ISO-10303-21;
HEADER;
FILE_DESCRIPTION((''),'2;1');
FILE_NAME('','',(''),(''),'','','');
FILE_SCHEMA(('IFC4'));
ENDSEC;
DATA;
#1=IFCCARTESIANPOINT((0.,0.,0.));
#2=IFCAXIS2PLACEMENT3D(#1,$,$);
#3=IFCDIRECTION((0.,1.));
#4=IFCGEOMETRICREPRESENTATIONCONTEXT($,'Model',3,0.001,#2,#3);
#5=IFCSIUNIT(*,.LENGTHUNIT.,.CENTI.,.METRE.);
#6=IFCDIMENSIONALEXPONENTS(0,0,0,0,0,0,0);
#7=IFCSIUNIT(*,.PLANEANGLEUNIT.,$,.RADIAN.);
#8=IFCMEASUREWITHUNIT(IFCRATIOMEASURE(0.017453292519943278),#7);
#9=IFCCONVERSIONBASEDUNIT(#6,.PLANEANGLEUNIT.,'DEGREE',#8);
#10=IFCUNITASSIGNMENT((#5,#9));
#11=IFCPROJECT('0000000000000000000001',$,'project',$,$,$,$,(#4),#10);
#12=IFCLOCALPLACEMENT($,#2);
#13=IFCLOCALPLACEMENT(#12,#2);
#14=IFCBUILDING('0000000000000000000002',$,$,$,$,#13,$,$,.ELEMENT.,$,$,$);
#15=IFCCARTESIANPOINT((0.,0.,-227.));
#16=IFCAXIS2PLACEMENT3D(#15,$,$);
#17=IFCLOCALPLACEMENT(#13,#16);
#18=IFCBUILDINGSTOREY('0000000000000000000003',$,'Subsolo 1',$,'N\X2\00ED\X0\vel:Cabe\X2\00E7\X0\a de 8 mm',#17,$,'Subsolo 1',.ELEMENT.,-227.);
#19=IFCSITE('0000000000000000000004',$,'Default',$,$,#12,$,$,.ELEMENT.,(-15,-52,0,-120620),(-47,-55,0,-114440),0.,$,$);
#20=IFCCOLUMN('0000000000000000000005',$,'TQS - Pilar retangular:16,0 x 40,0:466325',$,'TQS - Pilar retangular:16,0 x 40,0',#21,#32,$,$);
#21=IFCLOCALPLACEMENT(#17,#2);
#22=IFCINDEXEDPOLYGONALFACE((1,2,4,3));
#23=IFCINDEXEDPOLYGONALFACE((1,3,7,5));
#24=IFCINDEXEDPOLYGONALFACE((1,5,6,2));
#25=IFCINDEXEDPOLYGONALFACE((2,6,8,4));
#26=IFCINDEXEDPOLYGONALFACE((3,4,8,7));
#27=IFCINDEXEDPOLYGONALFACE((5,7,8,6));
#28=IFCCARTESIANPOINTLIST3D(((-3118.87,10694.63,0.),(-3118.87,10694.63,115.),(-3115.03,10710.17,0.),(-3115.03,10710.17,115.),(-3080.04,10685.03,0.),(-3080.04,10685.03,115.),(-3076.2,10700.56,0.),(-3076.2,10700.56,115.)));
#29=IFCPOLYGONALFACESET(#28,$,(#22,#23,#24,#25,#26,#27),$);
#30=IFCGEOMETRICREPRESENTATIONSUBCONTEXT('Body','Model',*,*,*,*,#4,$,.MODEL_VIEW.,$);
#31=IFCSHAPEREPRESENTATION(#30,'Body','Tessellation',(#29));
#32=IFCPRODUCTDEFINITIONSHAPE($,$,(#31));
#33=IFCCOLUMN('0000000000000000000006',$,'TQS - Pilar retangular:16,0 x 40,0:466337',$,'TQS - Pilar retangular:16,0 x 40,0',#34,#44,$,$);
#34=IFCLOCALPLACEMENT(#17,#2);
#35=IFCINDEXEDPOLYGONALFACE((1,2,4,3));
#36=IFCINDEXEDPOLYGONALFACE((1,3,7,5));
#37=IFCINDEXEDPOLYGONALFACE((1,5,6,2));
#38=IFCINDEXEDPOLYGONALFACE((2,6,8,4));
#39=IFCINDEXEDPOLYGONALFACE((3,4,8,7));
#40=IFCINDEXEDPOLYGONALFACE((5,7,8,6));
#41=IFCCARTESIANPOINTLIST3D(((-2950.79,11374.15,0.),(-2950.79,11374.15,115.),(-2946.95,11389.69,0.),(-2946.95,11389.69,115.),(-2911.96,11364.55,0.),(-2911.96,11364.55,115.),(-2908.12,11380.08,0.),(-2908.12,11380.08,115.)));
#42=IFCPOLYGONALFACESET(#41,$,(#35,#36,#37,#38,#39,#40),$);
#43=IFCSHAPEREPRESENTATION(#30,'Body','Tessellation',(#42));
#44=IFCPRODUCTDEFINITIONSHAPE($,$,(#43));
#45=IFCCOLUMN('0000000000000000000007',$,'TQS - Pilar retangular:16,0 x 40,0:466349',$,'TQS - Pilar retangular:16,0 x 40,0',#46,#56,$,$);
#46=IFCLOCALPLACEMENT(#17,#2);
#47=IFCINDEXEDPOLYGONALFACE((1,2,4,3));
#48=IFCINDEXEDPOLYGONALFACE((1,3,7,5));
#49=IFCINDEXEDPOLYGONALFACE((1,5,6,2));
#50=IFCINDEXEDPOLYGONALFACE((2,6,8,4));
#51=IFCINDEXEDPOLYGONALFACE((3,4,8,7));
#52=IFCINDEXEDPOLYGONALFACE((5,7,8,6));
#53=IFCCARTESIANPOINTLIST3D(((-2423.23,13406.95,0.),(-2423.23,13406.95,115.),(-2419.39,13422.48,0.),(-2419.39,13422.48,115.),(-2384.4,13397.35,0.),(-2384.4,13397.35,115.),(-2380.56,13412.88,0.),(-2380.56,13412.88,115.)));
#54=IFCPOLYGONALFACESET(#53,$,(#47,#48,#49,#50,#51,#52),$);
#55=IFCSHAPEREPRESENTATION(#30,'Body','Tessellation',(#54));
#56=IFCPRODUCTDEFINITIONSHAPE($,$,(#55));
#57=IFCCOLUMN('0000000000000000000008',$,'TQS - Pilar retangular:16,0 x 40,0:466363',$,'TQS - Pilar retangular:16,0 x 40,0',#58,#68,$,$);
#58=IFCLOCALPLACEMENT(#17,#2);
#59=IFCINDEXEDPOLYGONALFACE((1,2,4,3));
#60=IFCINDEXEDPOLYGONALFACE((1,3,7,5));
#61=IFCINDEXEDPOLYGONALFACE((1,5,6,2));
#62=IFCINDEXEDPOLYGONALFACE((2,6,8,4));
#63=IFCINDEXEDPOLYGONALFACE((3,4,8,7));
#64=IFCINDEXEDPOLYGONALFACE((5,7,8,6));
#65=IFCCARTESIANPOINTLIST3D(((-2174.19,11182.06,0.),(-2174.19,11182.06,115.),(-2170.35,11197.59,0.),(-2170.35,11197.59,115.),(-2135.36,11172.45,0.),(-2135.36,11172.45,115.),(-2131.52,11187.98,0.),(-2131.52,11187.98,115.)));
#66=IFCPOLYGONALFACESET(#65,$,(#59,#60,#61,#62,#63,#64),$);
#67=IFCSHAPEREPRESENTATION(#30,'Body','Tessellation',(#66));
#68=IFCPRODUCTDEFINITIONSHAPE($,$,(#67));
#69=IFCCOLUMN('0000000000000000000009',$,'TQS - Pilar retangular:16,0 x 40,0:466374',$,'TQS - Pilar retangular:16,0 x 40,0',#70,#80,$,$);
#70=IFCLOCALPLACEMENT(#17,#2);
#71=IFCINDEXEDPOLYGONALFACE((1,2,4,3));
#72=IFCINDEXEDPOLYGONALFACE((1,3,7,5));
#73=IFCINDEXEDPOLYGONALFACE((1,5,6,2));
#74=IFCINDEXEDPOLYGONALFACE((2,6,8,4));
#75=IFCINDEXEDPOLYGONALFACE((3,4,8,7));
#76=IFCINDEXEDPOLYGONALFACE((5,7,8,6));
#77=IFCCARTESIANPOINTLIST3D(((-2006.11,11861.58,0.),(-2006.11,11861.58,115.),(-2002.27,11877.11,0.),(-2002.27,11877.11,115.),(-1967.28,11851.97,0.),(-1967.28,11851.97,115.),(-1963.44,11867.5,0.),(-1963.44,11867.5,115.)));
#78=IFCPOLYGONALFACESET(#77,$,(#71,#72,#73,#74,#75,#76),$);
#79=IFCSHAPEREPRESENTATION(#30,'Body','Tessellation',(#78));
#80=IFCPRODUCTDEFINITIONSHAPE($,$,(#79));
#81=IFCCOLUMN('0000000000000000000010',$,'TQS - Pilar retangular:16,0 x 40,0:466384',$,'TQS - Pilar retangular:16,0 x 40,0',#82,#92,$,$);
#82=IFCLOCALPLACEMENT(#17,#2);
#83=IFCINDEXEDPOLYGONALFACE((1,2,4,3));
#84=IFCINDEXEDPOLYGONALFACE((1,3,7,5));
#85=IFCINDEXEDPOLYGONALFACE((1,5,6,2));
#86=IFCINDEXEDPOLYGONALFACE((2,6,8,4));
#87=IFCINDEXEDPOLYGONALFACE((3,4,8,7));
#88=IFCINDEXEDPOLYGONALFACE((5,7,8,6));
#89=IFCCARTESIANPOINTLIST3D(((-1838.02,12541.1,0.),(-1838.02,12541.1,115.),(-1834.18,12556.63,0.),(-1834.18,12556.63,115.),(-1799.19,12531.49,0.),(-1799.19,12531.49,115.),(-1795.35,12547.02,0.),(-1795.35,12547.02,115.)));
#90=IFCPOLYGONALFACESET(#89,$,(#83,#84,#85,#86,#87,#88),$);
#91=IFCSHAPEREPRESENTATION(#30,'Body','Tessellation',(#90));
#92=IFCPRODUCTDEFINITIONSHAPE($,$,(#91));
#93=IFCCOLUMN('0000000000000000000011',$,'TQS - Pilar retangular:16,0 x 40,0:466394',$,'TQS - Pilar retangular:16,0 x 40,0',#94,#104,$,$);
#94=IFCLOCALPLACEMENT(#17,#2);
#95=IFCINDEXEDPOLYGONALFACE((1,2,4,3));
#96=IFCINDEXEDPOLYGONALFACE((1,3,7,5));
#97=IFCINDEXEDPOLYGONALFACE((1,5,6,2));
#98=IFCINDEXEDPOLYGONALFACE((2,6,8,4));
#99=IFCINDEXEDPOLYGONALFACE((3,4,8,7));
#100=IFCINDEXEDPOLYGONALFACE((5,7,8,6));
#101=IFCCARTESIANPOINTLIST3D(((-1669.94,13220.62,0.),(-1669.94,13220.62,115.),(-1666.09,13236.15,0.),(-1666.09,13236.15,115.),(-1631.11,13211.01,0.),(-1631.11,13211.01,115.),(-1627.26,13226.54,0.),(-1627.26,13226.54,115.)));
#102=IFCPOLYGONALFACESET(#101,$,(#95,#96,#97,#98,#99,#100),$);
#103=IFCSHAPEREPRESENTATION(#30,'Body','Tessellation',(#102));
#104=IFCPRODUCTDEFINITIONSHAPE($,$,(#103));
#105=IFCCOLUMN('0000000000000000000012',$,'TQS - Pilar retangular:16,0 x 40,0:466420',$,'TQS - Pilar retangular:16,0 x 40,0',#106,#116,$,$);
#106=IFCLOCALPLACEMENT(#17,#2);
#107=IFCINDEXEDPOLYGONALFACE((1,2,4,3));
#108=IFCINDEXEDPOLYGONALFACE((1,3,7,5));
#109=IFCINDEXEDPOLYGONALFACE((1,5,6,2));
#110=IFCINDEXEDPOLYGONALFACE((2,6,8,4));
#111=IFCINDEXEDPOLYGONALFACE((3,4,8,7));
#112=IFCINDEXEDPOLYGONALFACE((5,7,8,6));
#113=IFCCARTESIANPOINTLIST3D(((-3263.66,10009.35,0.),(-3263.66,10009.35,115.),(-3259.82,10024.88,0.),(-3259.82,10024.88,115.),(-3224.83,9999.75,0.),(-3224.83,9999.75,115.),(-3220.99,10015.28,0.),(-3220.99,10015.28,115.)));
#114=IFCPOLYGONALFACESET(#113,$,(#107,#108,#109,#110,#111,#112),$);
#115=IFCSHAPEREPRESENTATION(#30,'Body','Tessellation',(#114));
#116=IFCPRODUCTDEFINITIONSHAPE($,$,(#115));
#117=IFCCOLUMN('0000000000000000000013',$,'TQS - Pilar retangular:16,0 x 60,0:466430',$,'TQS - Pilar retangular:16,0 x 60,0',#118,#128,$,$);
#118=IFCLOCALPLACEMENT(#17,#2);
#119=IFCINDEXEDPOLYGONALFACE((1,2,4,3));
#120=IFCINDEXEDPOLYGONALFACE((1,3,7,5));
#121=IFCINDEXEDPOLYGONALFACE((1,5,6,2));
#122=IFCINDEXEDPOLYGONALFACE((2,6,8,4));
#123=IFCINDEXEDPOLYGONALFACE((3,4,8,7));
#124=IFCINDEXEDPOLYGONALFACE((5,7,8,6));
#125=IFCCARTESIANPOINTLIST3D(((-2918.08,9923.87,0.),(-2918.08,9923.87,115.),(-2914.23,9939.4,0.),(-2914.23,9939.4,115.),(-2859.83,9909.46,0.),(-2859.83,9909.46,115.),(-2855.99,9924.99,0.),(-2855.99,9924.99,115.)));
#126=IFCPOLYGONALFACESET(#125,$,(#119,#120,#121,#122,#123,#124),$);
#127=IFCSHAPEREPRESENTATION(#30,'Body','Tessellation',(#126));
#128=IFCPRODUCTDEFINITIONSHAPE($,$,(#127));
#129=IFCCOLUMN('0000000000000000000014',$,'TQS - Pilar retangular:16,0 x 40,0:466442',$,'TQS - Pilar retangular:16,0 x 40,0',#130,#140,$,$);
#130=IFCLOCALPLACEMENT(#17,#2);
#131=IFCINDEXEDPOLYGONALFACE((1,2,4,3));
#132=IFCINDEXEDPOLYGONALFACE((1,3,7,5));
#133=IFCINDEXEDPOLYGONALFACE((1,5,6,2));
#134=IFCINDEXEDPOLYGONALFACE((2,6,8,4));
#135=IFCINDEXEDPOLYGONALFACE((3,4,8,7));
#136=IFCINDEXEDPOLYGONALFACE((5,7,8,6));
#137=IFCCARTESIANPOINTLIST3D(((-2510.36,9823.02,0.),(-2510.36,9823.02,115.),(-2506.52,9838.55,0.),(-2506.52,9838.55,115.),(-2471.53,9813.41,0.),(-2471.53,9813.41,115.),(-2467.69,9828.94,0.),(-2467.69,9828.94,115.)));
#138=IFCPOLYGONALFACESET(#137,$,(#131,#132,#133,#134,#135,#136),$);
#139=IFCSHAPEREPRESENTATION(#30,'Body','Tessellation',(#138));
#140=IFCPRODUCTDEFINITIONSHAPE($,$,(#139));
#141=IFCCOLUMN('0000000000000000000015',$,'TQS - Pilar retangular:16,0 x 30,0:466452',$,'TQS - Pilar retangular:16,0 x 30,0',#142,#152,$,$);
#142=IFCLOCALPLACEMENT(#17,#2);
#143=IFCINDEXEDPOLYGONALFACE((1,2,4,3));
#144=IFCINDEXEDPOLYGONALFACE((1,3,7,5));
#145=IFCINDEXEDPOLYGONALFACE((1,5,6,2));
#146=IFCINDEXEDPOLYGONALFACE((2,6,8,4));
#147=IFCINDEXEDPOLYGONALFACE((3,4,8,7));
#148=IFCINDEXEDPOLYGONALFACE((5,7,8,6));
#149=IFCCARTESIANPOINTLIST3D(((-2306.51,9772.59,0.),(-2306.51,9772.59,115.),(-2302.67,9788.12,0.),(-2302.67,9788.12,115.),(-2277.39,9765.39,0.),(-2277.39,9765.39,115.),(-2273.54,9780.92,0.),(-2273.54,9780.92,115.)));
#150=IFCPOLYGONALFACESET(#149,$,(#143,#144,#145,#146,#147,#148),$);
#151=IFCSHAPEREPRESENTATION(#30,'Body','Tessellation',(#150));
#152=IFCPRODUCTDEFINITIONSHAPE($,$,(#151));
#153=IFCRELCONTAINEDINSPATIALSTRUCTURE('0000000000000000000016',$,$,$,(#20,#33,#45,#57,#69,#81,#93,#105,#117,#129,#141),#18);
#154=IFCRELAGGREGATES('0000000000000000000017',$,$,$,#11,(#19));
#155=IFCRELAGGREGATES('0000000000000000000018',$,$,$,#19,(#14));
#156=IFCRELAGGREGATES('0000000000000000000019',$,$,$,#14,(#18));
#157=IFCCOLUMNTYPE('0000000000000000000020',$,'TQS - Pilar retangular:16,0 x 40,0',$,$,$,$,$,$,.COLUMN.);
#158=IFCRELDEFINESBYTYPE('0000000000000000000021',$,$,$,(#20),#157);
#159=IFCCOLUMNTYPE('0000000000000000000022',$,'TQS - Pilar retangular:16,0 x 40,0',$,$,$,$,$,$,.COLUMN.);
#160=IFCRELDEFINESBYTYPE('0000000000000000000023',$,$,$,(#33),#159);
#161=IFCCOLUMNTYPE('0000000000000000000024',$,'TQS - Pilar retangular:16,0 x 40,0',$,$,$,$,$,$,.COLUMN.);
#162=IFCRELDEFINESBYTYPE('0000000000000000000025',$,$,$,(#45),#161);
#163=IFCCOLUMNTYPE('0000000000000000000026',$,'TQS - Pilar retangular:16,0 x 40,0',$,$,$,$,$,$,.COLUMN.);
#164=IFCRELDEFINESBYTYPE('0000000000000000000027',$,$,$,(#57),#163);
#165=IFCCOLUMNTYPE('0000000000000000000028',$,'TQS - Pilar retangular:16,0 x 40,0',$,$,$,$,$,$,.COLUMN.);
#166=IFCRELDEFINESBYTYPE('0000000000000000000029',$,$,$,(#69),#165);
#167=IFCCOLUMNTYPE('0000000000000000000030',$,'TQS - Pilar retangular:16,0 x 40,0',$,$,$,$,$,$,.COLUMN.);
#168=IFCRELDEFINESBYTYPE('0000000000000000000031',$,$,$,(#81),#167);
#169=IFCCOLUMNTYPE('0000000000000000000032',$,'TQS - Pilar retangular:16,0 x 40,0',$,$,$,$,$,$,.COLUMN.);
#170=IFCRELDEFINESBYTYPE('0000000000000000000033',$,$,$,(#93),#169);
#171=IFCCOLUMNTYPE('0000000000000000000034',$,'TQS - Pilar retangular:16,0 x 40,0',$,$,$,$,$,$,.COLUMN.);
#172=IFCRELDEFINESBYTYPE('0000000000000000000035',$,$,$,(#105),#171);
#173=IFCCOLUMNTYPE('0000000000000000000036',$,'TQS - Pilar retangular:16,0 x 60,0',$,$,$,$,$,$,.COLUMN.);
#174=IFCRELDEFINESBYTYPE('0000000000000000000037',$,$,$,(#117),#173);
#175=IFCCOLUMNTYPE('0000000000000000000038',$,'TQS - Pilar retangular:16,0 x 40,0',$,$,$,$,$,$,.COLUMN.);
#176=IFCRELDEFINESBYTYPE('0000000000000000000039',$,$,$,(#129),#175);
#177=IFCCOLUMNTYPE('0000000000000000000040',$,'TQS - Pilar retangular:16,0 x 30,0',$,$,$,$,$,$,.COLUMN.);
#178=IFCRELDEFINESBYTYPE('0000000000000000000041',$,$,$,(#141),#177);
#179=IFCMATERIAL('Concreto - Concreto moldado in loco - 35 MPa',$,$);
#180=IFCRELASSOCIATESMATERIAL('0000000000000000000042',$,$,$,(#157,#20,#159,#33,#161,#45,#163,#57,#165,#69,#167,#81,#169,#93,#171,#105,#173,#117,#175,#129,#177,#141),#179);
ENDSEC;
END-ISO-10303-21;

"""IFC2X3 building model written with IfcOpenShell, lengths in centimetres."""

from ifc_helpers import new_model, entity, si_unit, converted_unit, direction, frame, origin, origin_2d_with_axis, place, context, subcontext, project, spatial, rectangle, extrude, source, transform, mapped, material, type_object, type_shapes, element, save


model = new_model("IFC2X3")

# Units and contexts
model_context = context("Model", 3, precision=0.001, world=origin(), true_north=direction((0.0, 1.0)))
body_context = subcontext(model_context, "Body", "Model", "MODEL_VIEW")
ifc_project = project(units=[si_unit("LENGTHUNIT", "METRE", prefix="CENTI"), converted_unit("PLANEANGLEUNIT", "DEGREE", entity("IfcRatioMeasure", 0.017453292519943278), si_unit("PLANEANGLEUNIT", "RADIAN"), dimensions=[0, 0, 0, 0, 0, 0, 0])], contexts=[model_context])

# Site, building, storey
site_placement = place(None, origin())
site = spatial("IfcSite", under=ifc_project, at=site_placement, Name="Default", CompositionType="ELEMENT", RefLatitude=(-15, -52, 0, -120620), RefLongitude=(-47, -55, 0, -114440), RefElevation=0.0)
building_placement = place(site_placement, origin())
building = spatial("IfcBuilding", under=site, at=building_placement, CompositionType="ELEMENT")
storey_placement = place(building_placement, frame((0.0, 0.0, -227.0)))
storey = spatial("IfcBuildingStorey", under=building, at=storey_placement, Name="Subsolo 1", ObjectType="Nível:Cabeça de 8 mm", LongName="Subsolo 1", CompositionType="ELEMENT", Elevation=-227.0)

# Columns
ifc_material = material(Name="Concreto - Concreto moldado in loco - 35 MPa")
column_type_1 = type_object("IfcColumnType", Name="TQS - Pilar retangular:16,0 x 40,0", PredefinedType="COLUMN", material=ifc_material)
shared_shape_1 = source(origin(), body_context, "Body", "SweptSolid", [
    extrude(rectangle(XDim=40.0, YDim=16.0, at=origin_2d_with_axis()), frame((-3097.54, 10697.6, -227.0), z_axis=(0.0, 0.0, 1.0), x_axis=(-0.970743, 0.240122, 0.0)), (0.0, 0.0, 1.0), 115.0),
])
type_shapes(column_type_1, [shared_shape_1])
column_1_placement = place(storey_placement, frame((0.0, 0.0, 227.0)))
element("IfcColumn", 1, at=column_1_placement, inside=storey, type_object=column_type_1, material=ifc_material, Name="TQS - Pilar retangular:16,0 x 40,0:466325", ObjectType="TQS - Pilar retangular:16,0 x 40,0", context=body_context, shape_type="MappedRepresentation", body=[
    mapped(shared_shape_1, transform((0.0, 0.0, 0.0), scale=1.0)),
])
column_type_2 = type_object("IfcColumnType", Name="TQS - Pilar retangular:16,0 x 40,0", PredefinedType="COLUMN", material=ifc_material)
shared_shape_2 = source(origin(), body_context, "Body", "SweptSolid", [
    extrude(rectangle(XDim=40.0, YDim=16.0, at=origin_2d_with_axis()), frame((-2929.45, 11377.12, -227.0), z_axis=(0.0, 0.0, 1.0), x_axis=(-0.970743, 0.240122, 0.0)), (0.0, 0.0, 1.0), 115.0),
])
type_shapes(column_type_2, [shared_shape_2])
column_2_placement = place(storey_placement, frame((0.0, 0.0, 227.0)))
element("IfcColumn", 2, at=column_2_placement, inside=storey, type_object=column_type_2, material=ifc_material, Name="TQS - Pilar retangular:16,0 x 40,0:466337", ObjectType="TQS - Pilar retangular:16,0 x 40,0", context=body_context, shape_type="MappedRepresentation", body=[
    mapped(shared_shape_2, transform((0.0, 0.0, 0.0), scale=1.0)),
])
column_type_3 = type_object("IfcColumnType", Name="TQS - Pilar retangular:16,0 x 40,0", PredefinedType="COLUMN", material=ifc_material)
shared_shape_3 = source(origin(), body_context, "Body", "SweptSolid", [
    extrude(rectangle(XDim=40.0, YDim=16.0, at=origin_2d_with_axis()), frame((-2401.9, 13409.91, -227.0), z_axis=(0.0, 0.0, 1.0), x_axis=(-0.970743, 0.240122, 0.0)), (0.0, 0.0, 1.0), 115.0),
])
type_shapes(column_type_3, [shared_shape_3])
column_3_placement = place(storey_placement, frame((0.0, 0.0, 227.0)))
element("IfcColumn", 3, at=column_3_placement, inside=storey, type_object=column_type_3, material=ifc_material, Name="TQS - Pilar retangular:16,0 x 40,0:466349", ObjectType="TQS - Pilar retangular:16,0 x 40,0", context=body_context, shape_type="MappedRepresentation", body=[
    mapped(shared_shape_3, transform((0.0, 0.0, 0.0), scale=1.0)),
])
column_type_4 = type_object("IfcColumnType", Name="TQS - Pilar retangular:16,0 x 40,0", PredefinedType="COLUMN", material=ifc_material)
shared_shape_4 = source(origin(), body_context, "Body", "SweptSolid", [
    extrude(rectangle(XDim=40.0, YDim=16.0, at=origin_2d_with_axis()), frame((-2152.86, 11185.02, -227.0), z_axis=(0.0, 0.0, 1.0), x_axis=(-0.970743, 0.240122, 0.0)), (0.0, 0.0, 1.0), 115.0),
])
type_shapes(column_type_4, [shared_shape_4])
column_4_placement = place(storey_placement, frame((0.0, 0.0, 227.0)))
element("IfcColumn", 4, at=column_4_placement, inside=storey, type_object=column_type_4, material=ifc_material, Name="TQS - Pilar retangular:16,0 x 40,0:466363", ObjectType="TQS - Pilar retangular:16,0 x 40,0", context=body_context, shape_type="MappedRepresentation", body=[
    mapped(shared_shape_4, transform((0.0, 0.0, 0.0), scale=1.0)),
])
column_type_5 = type_object("IfcColumnType", Name="TQS - Pilar retangular:16,0 x 40,0", PredefinedType="COLUMN", material=ifc_material)
shared_shape_5 = source(origin(), body_context, "Body", "SweptSolid", [
    extrude(rectangle(XDim=40.0, YDim=16.0, at=origin_2d_with_axis()), frame((-1984.77, 11864.54, -227.0), z_axis=(0.0, 0.0, 1.0), x_axis=(-0.970743, 0.240122, 0.0)), (0.0, 0.0, 1.0), 115.0),
])
type_shapes(column_type_5, [shared_shape_5])
column_5_placement = place(storey_placement, frame((0.0, 0.0, 227.0)))
element("IfcColumn", 5, at=column_5_placement, inside=storey, type_object=column_type_5, material=ifc_material, Name="TQS - Pilar retangular:16,0 x 40,0:466374", ObjectType="TQS - Pilar retangular:16,0 x 40,0", context=body_context, shape_type="MappedRepresentation", body=[
    mapped(shared_shape_5, transform((0.0, 0.0, 0.0), scale=1.0)),
])
column_type_6 = type_object("IfcColumnType", Name="TQS - Pilar retangular:16,0 x 40,0", PredefinedType="COLUMN", material=ifc_material)
shared_shape_6 = source(origin(), body_context, "Body", "SweptSolid", [
    extrude(rectangle(XDim=40.0, YDim=16.0, at=origin_2d_with_axis()), frame((-1816.69, 12544.06, -227.0), z_axis=(0.0, 0.0, 1.0), x_axis=(-0.970743, 0.240122, 0.0)), (0.0, 0.0, 1.0), 115.0),
])
type_shapes(column_type_6, [shared_shape_6])
column_6_placement = place(storey_placement, frame((0.0, 0.0, 227.0)))
element("IfcColumn", 6, at=column_6_placement, inside=storey, type_object=column_type_6, material=ifc_material, Name="TQS - Pilar retangular:16,0 x 40,0:466384", ObjectType="TQS - Pilar retangular:16,0 x 40,0", context=body_context, shape_type="MappedRepresentation", body=[
    mapped(shared_shape_6, transform((0.0, 0.0, 0.0), scale=1.0)),
])
column_type_7 = type_object("IfcColumnType", Name="TQS - Pilar retangular:16,0 x 40,0", PredefinedType="COLUMN", material=ifc_material)
shared_shape_7 = source(origin(), body_context, "Body", "SweptSolid", [
    extrude(rectangle(XDim=40.0, YDim=16.0, at=origin_2d_with_axis()), frame((-1648.6, 13223.58, -227.0), z_axis=(0.0, 0.0, 1.0), x_axis=(-0.970743, 0.240122, 0.0)), (0.0, 0.0, 1.0), 115.0),
])
type_shapes(column_type_7, [shared_shape_7])
column_7_placement = place(storey_placement, frame((0.0, 0.0, 227.0)))
element("IfcColumn", 7, at=column_7_placement, inside=storey, type_object=column_type_7, material=ifc_material, Name="TQS - Pilar retangular:16,0 x 40,0:466394", ObjectType="TQS - Pilar retangular:16,0 x 40,0", context=body_context, shape_type="MappedRepresentation", body=[
    mapped(shared_shape_7, transform((0.0, 0.0, 0.0), scale=1.0)),
])
column_type_8 = type_object("IfcColumnType", Name="TQS - Pilar retangular:16,0 x 40,0", PredefinedType="COLUMN", material=ifc_material)
shared_shape_8 = source(origin(), body_context, "Body", "SweptSolid", [
    extrude(rectangle(XDim=40.0, YDim=16.0, at=origin_2d_with_axis()), frame((-3242.33, 10012.31, -227.0), z_axis=(0.0, 0.0, 1.0), x_axis=(-0.970743, 0.240122, 0.0)), (0.0, 0.0, 1.0), 115.0),
])
type_shapes(column_type_8, [shared_shape_8])
column_8_placement = place(storey_placement, frame((0.0, 0.0, 227.0)))
element("IfcColumn", 8, at=column_8_placement, inside=storey, type_object=column_type_8, material=ifc_material, Name="TQS - Pilar retangular:16,0 x 40,0:466420", ObjectType="TQS - Pilar retangular:16,0 x 40,0", context=body_context, shape_type="MappedRepresentation", body=[
    mapped(shared_shape_8, transform((0.0, 0.0, 0.0), scale=1.0)),
])
column_type_9 = type_object("IfcColumnType", Name="TQS - Pilar retangular:16,0 x 60,0", PredefinedType="COLUMN", material=ifc_material)
shared_shape_9 = source(origin(), body_context, "Body", "SweptSolid", [
    extrude(rectangle(XDim=60.0, YDim=16.0, at=origin_2d_with_axis()), frame((-2887.03, 9924.43, -227.0), z_axis=(0.0, 0.0, 1.0), x_axis=(-0.970743, 0.240122, 0.0)), (0.0, 0.0, 1.0), 115.0),
])
type_shapes(column_type_9, [shared_shape_9])
column_9_placement = place(storey_placement, frame((0.0, 0.0, 227.0)))
element("IfcColumn", 9, at=column_9_placement, inside=storey, type_object=column_type_9, material=ifc_material, Name="TQS - Pilar retangular:16,0 x 60,0:466430", ObjectType="TQS - Pilar retangular:16,0 x 60,0", context=body_context, shape_type="MappedRepresentation", body=[
    mapped(shared_shape_9, transform((0.0, 0.0, 0.0), scale=1.0)),
])
column_type_10 = type_object("IfcColumnType", Name="TQS - Pilar retangular:16,0 x 40,0", PredefinedType="COLUMN", material=ifc_material)
shared_shape_10 = source(origin(), body_context, "Body", "SweptSolid", [
    extrude(rectangle(XDim=40.0, YDim=16.0, at=origin_2d_with_axis()), frame((-2489.03, 9825.98, -227.0), z_axis=(0.0, 0.0, 1.0), x_axis=(-0.970743, 0.240122, 0.0)), (0.0, 0.0, 1.0), 115.0),
])
type_shapes(column_type_10, [shared_shape_10])
column_10_placement = place(storey_placement, frame((0.0, 0.0, 227.0)))
element("IfcColumn", 10, at=column_10_placement, inside=storey, type_object=column_type_10, material=ifc_material, Name="TQS - Pilar retangular:16,0 x 40,0:466442", ObjectType="TQS - Pilar retangular:16,0 x 40,0", context=body_context, shape_type="MappedRepresentation", body=[
    mapped(shared_shape_10, transform((0.0, 0.0, 0.0), scale=1.0)),
])
column_type_11 = type_object("IfcColumnType", Name="TQS - Pilar retangular:16,0 x 30,0", PredefinedType="COLUMN", material=ifc_material)
shared_shape_11 = source(origin(), body_context, "Body", "SweptSolid", [
    extrude(rectangle(XDim=30.0, YDim=16.0, at=origin_2d_with_axis()), frame((-2290.03, 9776.75, -227.0), z_axis=(0.0, 0.0, 1.0), x_axis=(-0.970743, 0.240122, 0.0)), (0.0, 0.0, 1.0), 115.0),
])
type_shapes(column_type_11, [shared_shape_11])
column_11_placement = place(storey_placement, frame((0.0, 0.0, 227.0)))
element("IfcColumn", 11, at=column_11_placement, inside=storey, type_object=column_type_11, material=ifc_material, Name="TQS - Pilar retangular:16,0 x 30,0:466452", ObjectType="TQS - Pilar retangular:16,0 x 30,0", context=body_context, shape_type="MappedRepresentation", body=[
    mapped(shared_shape_11, transform((0.0, 0.0, 0.0), scale=1.0)),
])

save(model, "model.ifc")
